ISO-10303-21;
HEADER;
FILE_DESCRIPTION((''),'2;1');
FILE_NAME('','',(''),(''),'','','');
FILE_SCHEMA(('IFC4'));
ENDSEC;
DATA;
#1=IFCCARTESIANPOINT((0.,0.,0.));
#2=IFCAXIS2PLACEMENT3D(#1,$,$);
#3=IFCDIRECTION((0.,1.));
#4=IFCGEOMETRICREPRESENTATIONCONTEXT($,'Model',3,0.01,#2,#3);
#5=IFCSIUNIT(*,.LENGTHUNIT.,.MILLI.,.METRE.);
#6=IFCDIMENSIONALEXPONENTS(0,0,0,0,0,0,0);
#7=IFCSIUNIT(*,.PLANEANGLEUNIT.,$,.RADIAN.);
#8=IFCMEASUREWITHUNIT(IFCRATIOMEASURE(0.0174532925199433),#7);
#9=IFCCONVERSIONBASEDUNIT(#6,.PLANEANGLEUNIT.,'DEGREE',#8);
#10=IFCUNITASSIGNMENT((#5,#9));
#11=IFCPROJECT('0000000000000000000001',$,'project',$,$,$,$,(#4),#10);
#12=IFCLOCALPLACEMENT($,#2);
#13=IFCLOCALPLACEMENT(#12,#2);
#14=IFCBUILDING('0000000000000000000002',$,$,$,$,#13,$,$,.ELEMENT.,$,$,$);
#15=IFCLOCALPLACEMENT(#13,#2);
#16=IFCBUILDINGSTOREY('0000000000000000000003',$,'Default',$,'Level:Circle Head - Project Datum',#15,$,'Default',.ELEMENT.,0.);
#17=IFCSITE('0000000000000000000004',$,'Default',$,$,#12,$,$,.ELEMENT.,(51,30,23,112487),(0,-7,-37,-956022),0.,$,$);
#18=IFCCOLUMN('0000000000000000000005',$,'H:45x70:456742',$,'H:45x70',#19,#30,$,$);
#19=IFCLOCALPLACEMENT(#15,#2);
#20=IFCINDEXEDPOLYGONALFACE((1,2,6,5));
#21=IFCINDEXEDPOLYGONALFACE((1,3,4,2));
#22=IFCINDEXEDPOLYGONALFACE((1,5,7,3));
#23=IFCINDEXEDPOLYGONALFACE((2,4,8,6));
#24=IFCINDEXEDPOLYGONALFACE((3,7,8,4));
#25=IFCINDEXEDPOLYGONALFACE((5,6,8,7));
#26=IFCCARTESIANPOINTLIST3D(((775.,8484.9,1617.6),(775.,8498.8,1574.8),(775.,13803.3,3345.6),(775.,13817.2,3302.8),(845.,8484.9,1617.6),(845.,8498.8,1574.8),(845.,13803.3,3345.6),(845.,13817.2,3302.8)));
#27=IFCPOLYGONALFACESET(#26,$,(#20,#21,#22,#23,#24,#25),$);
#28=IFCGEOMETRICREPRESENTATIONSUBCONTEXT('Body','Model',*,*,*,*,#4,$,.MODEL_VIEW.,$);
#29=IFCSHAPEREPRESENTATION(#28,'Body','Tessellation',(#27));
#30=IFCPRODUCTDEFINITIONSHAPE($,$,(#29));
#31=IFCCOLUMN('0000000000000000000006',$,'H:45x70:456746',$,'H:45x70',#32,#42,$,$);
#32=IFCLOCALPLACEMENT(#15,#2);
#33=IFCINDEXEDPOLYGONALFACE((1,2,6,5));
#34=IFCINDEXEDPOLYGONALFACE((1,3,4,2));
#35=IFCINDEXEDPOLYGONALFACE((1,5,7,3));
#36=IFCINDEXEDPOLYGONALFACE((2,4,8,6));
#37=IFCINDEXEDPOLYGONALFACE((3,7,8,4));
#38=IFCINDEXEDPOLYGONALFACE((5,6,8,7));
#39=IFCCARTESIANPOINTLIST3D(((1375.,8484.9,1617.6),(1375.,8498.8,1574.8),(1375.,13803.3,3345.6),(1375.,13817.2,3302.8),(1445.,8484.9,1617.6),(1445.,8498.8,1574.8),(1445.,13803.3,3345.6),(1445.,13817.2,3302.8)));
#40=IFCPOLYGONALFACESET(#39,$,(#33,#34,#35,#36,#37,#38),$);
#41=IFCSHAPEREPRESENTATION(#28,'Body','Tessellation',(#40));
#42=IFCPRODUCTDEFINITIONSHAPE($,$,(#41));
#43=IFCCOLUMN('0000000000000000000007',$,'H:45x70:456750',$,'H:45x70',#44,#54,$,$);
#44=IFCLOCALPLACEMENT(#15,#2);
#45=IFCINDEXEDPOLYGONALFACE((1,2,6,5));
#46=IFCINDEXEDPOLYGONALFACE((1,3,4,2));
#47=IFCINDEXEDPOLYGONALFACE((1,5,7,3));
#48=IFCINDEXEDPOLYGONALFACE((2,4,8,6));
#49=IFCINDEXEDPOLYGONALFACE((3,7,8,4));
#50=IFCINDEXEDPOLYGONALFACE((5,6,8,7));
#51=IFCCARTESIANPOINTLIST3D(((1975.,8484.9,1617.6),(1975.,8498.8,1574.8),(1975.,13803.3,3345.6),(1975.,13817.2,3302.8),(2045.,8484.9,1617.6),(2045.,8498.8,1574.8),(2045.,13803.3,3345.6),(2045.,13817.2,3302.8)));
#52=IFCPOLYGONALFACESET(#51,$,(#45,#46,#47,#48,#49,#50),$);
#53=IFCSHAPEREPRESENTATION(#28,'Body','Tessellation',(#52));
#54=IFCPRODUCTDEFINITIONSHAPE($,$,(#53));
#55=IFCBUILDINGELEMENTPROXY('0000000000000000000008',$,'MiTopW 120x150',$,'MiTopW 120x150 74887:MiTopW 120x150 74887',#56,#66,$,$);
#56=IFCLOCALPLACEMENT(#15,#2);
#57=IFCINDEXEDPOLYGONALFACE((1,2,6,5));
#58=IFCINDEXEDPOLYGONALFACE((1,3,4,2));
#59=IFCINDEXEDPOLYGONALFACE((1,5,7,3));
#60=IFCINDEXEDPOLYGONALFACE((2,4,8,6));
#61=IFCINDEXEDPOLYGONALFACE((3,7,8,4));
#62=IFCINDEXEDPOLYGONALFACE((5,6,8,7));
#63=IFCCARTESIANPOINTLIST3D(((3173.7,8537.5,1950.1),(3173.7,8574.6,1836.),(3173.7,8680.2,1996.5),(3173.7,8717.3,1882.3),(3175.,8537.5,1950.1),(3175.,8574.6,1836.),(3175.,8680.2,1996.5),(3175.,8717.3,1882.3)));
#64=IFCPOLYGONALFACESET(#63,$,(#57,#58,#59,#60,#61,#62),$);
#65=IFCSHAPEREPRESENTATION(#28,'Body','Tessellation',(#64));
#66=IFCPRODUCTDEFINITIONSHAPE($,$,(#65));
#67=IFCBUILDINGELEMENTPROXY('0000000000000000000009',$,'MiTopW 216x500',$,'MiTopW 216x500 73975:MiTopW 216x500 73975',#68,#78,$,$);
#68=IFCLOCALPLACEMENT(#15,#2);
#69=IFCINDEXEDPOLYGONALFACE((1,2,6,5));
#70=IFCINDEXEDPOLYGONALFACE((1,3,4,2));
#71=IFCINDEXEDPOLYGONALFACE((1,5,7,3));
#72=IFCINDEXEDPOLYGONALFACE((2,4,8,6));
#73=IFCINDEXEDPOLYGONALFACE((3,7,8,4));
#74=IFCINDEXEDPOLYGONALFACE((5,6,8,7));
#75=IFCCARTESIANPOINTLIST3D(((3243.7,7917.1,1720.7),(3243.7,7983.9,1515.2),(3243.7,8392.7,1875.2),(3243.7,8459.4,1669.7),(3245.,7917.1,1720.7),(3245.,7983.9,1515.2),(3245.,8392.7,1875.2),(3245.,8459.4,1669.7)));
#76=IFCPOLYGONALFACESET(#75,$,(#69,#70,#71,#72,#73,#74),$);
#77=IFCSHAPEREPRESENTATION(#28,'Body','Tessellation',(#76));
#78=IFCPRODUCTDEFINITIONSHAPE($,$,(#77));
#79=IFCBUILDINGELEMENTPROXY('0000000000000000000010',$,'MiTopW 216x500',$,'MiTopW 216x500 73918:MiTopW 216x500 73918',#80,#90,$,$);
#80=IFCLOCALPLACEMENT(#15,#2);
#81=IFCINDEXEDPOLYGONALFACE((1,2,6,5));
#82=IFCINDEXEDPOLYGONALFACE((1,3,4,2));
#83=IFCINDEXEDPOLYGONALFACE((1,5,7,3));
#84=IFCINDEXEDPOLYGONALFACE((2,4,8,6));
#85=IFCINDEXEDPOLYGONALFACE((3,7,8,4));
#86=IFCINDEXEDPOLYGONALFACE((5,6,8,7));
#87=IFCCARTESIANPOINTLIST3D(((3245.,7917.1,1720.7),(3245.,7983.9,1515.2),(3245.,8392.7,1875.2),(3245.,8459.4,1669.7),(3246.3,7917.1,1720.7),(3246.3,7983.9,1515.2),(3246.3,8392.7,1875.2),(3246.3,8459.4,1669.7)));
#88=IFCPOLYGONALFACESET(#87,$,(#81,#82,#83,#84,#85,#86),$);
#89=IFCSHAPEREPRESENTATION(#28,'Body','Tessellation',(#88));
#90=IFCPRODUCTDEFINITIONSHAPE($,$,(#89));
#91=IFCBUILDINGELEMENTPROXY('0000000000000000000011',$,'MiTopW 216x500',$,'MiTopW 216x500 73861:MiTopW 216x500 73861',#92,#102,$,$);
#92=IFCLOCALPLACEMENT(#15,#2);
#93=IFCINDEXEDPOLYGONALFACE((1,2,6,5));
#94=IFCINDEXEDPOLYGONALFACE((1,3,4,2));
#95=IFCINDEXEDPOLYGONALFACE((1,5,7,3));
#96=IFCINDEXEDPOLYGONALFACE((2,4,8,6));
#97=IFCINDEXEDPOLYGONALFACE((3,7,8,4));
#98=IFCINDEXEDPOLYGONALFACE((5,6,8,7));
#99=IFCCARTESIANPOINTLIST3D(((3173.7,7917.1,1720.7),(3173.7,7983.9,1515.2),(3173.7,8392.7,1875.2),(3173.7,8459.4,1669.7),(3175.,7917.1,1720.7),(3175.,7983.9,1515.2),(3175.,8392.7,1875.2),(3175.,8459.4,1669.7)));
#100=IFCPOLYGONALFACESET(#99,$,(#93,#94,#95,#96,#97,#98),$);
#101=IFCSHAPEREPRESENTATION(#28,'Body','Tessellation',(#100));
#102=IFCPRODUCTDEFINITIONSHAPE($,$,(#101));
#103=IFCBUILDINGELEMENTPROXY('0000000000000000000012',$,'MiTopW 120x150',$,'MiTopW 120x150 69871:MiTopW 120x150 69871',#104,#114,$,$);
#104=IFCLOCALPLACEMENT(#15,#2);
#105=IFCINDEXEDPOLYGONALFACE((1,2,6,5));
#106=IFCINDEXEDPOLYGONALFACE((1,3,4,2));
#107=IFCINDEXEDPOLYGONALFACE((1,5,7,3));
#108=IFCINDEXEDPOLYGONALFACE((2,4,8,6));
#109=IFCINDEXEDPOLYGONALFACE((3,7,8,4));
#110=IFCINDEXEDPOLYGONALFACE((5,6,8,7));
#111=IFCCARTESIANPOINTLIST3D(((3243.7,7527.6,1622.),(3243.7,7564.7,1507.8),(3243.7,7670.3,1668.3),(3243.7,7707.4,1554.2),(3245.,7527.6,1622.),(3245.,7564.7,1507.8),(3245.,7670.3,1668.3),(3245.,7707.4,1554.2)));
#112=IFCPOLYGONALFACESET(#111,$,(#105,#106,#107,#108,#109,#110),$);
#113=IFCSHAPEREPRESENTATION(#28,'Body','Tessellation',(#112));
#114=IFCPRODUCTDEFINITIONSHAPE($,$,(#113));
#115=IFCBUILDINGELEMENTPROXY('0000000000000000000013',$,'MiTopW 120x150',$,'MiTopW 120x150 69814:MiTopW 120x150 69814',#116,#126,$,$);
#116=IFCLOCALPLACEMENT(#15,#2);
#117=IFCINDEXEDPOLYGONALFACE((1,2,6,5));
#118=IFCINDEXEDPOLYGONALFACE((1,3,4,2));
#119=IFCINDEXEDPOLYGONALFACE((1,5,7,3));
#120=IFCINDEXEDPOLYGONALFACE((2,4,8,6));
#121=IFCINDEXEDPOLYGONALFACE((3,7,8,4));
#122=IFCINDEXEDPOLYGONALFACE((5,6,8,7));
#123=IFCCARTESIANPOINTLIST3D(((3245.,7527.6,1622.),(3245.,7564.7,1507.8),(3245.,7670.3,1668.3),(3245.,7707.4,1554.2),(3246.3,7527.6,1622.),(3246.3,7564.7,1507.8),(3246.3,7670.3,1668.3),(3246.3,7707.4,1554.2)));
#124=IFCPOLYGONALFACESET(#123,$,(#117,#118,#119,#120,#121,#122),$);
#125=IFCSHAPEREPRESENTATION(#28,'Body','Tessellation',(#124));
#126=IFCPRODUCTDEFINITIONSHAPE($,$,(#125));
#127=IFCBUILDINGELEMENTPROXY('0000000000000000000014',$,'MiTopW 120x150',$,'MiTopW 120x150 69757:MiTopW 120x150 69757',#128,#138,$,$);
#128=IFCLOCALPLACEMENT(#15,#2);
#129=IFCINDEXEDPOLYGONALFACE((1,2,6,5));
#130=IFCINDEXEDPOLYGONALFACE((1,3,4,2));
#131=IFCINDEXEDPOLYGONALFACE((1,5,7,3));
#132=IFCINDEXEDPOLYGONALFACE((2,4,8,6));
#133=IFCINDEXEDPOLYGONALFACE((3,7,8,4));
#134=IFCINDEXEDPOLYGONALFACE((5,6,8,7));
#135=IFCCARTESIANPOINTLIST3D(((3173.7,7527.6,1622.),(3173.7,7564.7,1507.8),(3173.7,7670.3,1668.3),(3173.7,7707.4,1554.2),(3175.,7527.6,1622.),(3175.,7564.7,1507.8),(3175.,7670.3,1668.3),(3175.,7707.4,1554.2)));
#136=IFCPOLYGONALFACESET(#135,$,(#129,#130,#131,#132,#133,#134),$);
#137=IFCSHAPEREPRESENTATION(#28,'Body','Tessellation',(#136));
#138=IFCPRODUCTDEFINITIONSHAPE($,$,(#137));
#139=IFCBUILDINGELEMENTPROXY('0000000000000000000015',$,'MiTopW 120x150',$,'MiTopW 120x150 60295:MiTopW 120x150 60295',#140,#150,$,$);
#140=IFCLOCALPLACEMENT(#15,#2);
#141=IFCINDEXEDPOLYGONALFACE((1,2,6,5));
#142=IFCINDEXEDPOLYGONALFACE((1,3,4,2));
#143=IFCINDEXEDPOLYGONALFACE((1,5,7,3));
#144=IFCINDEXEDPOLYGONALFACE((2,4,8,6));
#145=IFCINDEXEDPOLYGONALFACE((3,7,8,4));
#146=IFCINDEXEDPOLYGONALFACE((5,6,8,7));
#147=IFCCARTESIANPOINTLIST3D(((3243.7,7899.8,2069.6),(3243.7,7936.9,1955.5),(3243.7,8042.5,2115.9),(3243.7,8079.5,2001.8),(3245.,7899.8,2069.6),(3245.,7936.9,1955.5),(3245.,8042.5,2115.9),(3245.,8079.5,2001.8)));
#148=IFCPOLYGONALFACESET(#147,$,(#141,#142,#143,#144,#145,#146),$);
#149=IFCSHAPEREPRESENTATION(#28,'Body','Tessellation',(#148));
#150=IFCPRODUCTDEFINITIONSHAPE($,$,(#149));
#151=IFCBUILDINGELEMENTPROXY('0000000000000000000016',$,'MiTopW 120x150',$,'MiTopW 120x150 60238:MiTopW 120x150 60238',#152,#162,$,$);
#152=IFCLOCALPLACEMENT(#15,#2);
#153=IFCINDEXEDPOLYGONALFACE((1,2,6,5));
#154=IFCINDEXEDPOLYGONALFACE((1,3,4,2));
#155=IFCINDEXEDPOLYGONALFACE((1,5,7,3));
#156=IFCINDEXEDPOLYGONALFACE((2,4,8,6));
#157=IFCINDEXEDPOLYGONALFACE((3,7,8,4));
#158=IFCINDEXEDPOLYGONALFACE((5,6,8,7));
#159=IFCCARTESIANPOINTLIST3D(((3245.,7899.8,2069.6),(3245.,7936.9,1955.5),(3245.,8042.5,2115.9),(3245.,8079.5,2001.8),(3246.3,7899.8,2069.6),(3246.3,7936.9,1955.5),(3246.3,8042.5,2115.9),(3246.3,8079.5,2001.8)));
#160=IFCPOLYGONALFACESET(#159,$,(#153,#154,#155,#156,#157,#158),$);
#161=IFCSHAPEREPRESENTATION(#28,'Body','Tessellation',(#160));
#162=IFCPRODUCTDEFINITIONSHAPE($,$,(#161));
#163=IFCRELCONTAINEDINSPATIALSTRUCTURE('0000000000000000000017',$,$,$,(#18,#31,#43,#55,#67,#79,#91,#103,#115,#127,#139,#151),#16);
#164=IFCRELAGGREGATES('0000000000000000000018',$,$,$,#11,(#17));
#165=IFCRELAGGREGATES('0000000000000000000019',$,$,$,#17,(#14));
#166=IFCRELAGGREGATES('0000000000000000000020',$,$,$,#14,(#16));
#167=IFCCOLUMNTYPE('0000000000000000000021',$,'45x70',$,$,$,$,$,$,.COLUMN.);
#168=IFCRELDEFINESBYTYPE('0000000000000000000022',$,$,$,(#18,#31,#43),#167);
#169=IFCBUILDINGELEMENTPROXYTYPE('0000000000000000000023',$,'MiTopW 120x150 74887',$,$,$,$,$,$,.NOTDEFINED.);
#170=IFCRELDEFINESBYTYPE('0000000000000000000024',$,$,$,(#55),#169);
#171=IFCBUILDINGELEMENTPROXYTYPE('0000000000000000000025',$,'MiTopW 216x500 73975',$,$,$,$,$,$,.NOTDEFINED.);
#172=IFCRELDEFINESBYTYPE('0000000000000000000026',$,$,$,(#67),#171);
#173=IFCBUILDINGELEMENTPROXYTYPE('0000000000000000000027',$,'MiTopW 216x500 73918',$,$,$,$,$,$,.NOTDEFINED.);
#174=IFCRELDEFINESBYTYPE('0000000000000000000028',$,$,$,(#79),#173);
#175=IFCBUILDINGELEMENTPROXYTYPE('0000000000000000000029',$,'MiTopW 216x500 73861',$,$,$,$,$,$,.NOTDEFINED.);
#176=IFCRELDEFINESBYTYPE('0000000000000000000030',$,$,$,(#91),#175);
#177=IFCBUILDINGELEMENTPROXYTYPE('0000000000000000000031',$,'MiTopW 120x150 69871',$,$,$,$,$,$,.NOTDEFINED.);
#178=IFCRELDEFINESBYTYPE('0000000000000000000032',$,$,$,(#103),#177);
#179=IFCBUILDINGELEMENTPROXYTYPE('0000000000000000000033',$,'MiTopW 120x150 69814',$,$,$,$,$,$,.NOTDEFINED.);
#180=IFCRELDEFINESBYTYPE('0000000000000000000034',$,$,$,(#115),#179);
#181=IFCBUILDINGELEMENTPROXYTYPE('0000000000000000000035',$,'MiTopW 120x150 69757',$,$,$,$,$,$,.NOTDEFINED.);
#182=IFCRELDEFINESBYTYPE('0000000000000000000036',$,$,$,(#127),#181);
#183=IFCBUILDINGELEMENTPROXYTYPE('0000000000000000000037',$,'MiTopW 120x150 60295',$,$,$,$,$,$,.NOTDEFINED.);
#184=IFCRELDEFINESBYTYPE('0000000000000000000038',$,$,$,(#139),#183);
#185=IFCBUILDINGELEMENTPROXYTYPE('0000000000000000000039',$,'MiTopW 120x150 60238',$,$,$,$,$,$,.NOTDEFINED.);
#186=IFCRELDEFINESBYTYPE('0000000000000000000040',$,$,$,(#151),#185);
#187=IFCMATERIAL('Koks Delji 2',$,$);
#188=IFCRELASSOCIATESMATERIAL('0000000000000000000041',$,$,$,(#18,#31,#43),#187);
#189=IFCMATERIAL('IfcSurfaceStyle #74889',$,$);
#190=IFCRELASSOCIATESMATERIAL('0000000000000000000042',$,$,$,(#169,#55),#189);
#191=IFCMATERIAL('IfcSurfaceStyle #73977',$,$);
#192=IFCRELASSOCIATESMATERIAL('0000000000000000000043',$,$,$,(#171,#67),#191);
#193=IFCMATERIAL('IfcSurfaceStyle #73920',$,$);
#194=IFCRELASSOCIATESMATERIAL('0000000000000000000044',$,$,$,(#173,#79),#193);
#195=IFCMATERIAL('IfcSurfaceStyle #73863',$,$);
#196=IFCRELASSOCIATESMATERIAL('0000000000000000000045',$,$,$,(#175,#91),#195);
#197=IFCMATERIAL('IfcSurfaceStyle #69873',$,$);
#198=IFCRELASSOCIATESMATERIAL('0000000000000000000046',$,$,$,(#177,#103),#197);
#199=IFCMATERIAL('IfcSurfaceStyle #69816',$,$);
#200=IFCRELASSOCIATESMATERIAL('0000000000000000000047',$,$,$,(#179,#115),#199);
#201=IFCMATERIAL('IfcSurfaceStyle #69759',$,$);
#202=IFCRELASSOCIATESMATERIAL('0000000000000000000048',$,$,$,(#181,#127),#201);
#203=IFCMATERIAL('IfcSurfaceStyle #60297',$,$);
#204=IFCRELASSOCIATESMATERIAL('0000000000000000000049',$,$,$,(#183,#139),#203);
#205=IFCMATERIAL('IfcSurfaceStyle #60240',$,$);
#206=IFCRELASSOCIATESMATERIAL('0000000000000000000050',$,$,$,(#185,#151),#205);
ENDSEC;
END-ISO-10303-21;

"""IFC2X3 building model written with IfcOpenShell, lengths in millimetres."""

from ifc_helpers import new_model, entity, si_unit, converted_unit, direction, frame, frame_2d, origin, place, context, subcontext, project, spatial, polyline, rectangle, outline, extrude, source, transform, mapped, material, type_object, type_shapes, element, save


model = new_model("IFC2X3")

# Units and contexts
model_context = context("Model", 3, precision=0.01, world=origin(), true_north=direction((0.0, 1.0)))
body_context = subcontext(model_context, "Body", "Model", "MODEL_VIEW")
ifc_project = project(units=[si_unit("LENGTHUNIT", "METRE", prefix="MILLI"), converted_unit("PLANEANGLEUNIT", "DEGREE", entity("IfcRatioMeasure", 0.0174532925199433), si_unit("PLANEANGLEUNIT", "RADIAN"), dimensions=[0, 0, 0, 0, 0, 0, 0])], contexts=[model_context])

# Site, building, storey
site_placement = place(None, origin())
site = spatial("IfcSite", under=ifc_project, at=site_placement, Name="Default", CompositionType="ELEMENT", RefLatitude=(51, 30, 23, 112487), RefLongitude=(0, -7, -37, -956022), RefElevation=0.0)
building_placement = place(site_placement, origin())
building = spatial("IfcBuilding", under=site, at=building_placement, CompositionType="ELEMENT")
storey_placement = place(building_placement, origin())
storey = spatial("IfcBuildingStorey", under=building, at=storey_placement, Name="Default", ObjectType="Level:Circle Head - Project Datum", LongName="Default", CompositionType="ELEMENT", Elevation=0.0)

# Columns
ifc_material_1 = material(Name="Koks Delji 2")
column_type_1 = type_object("IfcColumnType", Name="45x70", PredefinedType="COLUMN")
shared_shape_1 = source(origin(), body_context, "Body", "SweptSolid", [
    extrude(rectangle(XDim=5592.1, YDim=70.0, at=frame_2d((0.0, 0.0), x_axis=(1.0, 0.0))), frame((2659.2, 237.8, 864.0), z_axis=(-0.309017, 0.0, 0.951057), x_axis=(-0.951057, 0.0, -0.309017)), (0.0, 0.0, 1.0), 45.0),
])
type_shapes(column_type_1, [shared_shape_1])
for number, where, z_axis, x_axis, name in (
    (1, (1047.8, 8498.8, 1574.8), (0.0, 0.0, 1.0), (0.0, 1.0, 0.0), "H:45x70:456742"),
    (2, (1647.8, 8498.8, 1574.8), (0.0, 0.0, 1.0), (0.0, 1.0, 0.0), "H:45x70:456746"),
    (3, (2247.8, 8498.8, 1574.8), (0.0, 0.0, 1.0), (0.0, 1.0, 0.0), "H:45x70:456750"),
):
    element("IfcColumn", number, at=place(storey_placement, frame(where, z_axis=z_axis, x_axis=x_axis)), inside=storey, type_object=column_type_1, material=ifc_material_1, Name=name, ObjectType="H:45x70", context=body_context, shape_type="MappedRepresentation", body=[
        mapped(shared_shape_1, transform((0.0, 0.0, 0.0), scale=1.0)),
    ])

# Building element proxies
ifc_material_2 = material(Name="IfcSurfaceStyle #74889")
building_element_proxy_type_1 = type_object("IfcBuildingElementProxyType", Name="MiTopW 120x150 74887", PredefinedType="NOTDEFINED", material=ifc_material_2)
shared_shape_2 = source(origin(), body_context, "Body", "SweptSolid", [
    extrude(outline(polyline([(-75.0, -60.0), (75.0, -60.0), (75.0, 60.0), (-75.0, 60.0), (-75.0, -60.0)])), frame((75.0, 60.0, 0.0), z_axis=(0.0, 0.0, 1.0), x_axis=(-1.0, 0.0, 0.0)), (0.0, 0.0, 1.0), 1.3),
])
type_shapes(building_element_proxy_type_1, [shared_shape_2])
proxy_1_placement = place(building_placement, frame((3175.0, 8537.5, 1950.1), z_axis=(-1.0, 0.0, 0.0), x_axis=(0.0, 0.951057, 0.309017)))
element("IfcBuildingElementProxy", 4, at=proxy_1_placement, inside=storey, type_object=building_element_proxy_type_1, material=ifc_material_2, Name="MiTopW 120x150", ObjectType="MiTopW 120x150 74887:MiTopW 120x150 74887", context=body_context, shape_type="MappedRepresentation", body=[
    mapped(shared_shape_2, transform((0.0, 0.0, 0.0), scale=1.0)),
])
ifc_material_3 = material(Name="IfcSurfaceStyle #73977")
building_element_proxy_type_2 = type_object("IfcBuildingElementProxyType", Name="MiTopW 216x500 73975", PredefinedType="NOTDEFINED", material=ifc_material_3)
shared_shape_3 = source(origin(), body_context, "Body", "SweptSolid", [
    extrude(outline(polyline([(-250.0, -108.0), (250.0, -108.0), (250.0, 108.0), (-250.0, 108.0), (-250.0, -108.0)])), frame((250.0, 108.0, 0.0), z_axis=(0.0, 0.0, 1.0), x_axis=(-1.0, 0.0, 0.0)), (0.0, 0.0, 1.0), 1.3),
])
type_shapes(building_element_proxy_type_2, [shared_shape_3])
proxy_2_placement = place(building_placement, frame((3245.0, 7917.1, 1720.7), z_axis=(-1.0, 0.0, 0.0), x_axis=(0.0, 0.951057, 0.309017)))
element("IfcBuildingElementProxy", 5, at=proxy_2_placement, inside=storey, type_object=building_element_proxy_type_2, material=ifc_material_3, Name="MiTopW 216x500", ObjectType="MiTopW 216x500 73975:MiTopW 216x500 73975", context=body_context, shape_type="MappedRepresentation", body=[
    mapped(shared_shape_3, transform((0.0, 0.0, 0.0), scale=1.0)),
])
ifc_material_4 = material(Name="IfcSurfaceStyle #73920")
building_element_proxy_type_3 = type_object("IfcBuildingElementProxyType", Name="MiTopW 216x500 73918", PredefinedType="NOTDEFINED", material=ifc_material_4)
shared_shape_4 = source(origin(), body_context, "Body", "SweptSolid", [
    extrude(outline(polyline([(-250.0, -108.0), (250.0, -108.0), (250.0, 108.0), (-250.0, 108.0), (-250.0, -108.0)])), frame((250.0, 108.0, 0.0), z_axis=(0.0, 0.0, 1.0), x_axis=(-1.0, 0.0, 0.0)), (0.0, 0.0, 1.0), 1.3),
])
type_shapes(building_element_proxy_type_3, [shared_shape_4])
proxy_3_placement = place(building_placement, frame((3246.3, 7917.1, 1720.7), z_axis=(-1.0, 0.0, 0.0), x_axis=(0.0, 0.951057, 0.309017)))
element("IfcBuildingElementProxy", 6, at=proxy_3_placement, inside=storey, type_object=building_element_proxy_type_3, material=ifc_material_4, Name="MiTopW 216x500", ObjectType="MiTopW 216x500 73918:MiTopW 216x500 73918", context=body_context, shape_type="MappedRepresentation", body=[
    mapped(shared_shape_4, transform((0.0, 0.0, 0.0), scale=1.0)),
])
ifc_material_5 = material(Name="IfcSurfaceStyle #73863")
building_element_proxy_type_4 = type_object("IfcBuildingElementProxyType", Name="MiTopW 216x500 73861", PredefinedType="NOTDEFINED", material=ifc_material_5)
shared_shape_5 = source(origin(), body_context, "Body", "SweptSolid", [
    extrude(outline(polyline([(-250.0, -108.0), (250.0, -108.0), (250.0, 108.0), (-250.0, 108.0), (-250.0, -108.0)])), frame((250.0, 108.0, 0.0), z_axis=(0.0, 0.0, 1.0), x_axis=(-1.0, 0.0, 0.0)), (0.0, 0.0, 1.0), 1.3),
])
type_shapes(building_element_proxy_type_4, [shared_shape_5])
proxy_4_placement = place(building_placement, frame((3175.0, 7917.1, 1720.7), z_axis=(-1.0, 0.0, 0.0), x_axis=(0.0, 0.951057, 0.309017)))
element("IfcBuildingElementProxy", 7, at=proxy_4_placement, inside=storey, type_object=building_element_proxy_type_4, material=ifc_material_5, Name="MiTopW 216x500", ObjectType="MiTopW 216x500 73861:MiTopW 216x500 73861", context=body_context, shape_type="MappedRepresentation", body=[
    mapped(shared_shape_5, transform((0.0, 0.0, 0.0), scale=1.0)),
])
ifc_material_6 = material(Name="IfcSurfaceStyle #69873")
building_element_proxy_type_5 = type_object("IfcBuildingElementProxyType", Name="MiTopW 120x150 69871", PredefinedType="NOTDEFINED", material=ifc_material_6)
shared_shape_6 = source(origin(), body_context, "Body", "SweptSolid", [
    extrude(outline(polyline([(-75.0, -60.0), (75.0, -60.0), (75.0, 60.0), (-75.0, 60.0), (-75.0, -60.0)])), frame((75.0, 60.0, 0.0), z_axis=(0.0, 0.0, 1.0), x_axis=(-1.0, 0.0, 0.0)), (0.0, 0.0, 1.0), 1.3),
])
type_shapes(building_element_proxy_type_5, [shared_shape_6])
proxy_5_placement = place(building_placement, frame((3245.0, 7527.6, 1622.0), z_axis=(-1.0, 0.0, 0.0), x_axis=(0.0, 0.951057, 0.309017)))
element("IfcBuildingElementProxy", 8, at=proxy_5_placement, inside=storey, type_object=building_element_proxy_type_5, material=ifc_material_6, Name="MiTopW 120x150", ObjectType="MiTopW 120x150 69871:MiTopW 120x150 69871", context=body_context, shape_type="MappedRepresentation", body=[
    mapped(shared_shape_6, transform((0.0, 0.0, 0.0), scale=1.0)),
])
ifc_material_7 = material(Name="IfcSurfaceStyle #69816")
building_element_proxy_type_6 = type_object("IfcBuildingElementProxyType", Name="MiTopW 120x150 69814", PredefinedType="NOTDEFINED", material=ifc_material_7)
shared_shape_7 = source(origin(), body_context, "Body", "SweptSolid", [
    extrude(outline(polyline([(-75.0, -60.0), (75.0, -60.0), (75.0, 60.0), (-75.0, 60.0), (-75.0, -60.0)])), frame((75.0, 60.0, 0.0), z_axis=(0.0, 0.0, 1.0), x_axis=(-1.0, 0.0, 0.0)), (0.0, 0.0, 1.0), 1.3),
])
type_shapes(building_element_proxy_type_6, [shared_shape_7])
proxy_6_placement = place(building_placement, frame((3246.3, 7527.6, 1622.0), z_axis=(-1.0, 0.0, 0.0), x_axis=(0.0, 0.951057, 0.309017)))
element("IfcBuildingElementProxy", 9, at=proxy_6_placement, inside=storey, type_object=building_element_proxy_type_6, material=ifc_material_7, Name="MiTopW 120x150", ObjectType="MiTopW 120x150 69814:MiTopW 120x150 69814", context=body_context, shape_type="MappedRepresentation", body=[
    mapped(shared_shape_7, transform((0.0, 0.0, 0.0), scale=1.0)),
])
ifc_material_8 = material(Name="IfcSurfaceStyle #69759")
building_element_proxy_type_7 = type_object("IfcBuildingElementProxyType", Name="MiTopW 120x150 69757", PredefinedType="NOTDEFINED", material=ifc_material_8)
shared_shape_8 = source(origin(), body_context, "Body", "SweptSolid", [
    extrude(outline(polyline([(-75.0, -60.0), (75.0, -60.0), (75.0, 60.0), (-75.0, 60.0), (-75.0, -60.0)])), frame((75.0, 60.0, 0.0), z_axis=(0.0, 0.0, 1.0), x_axis=(-1.0, 0.0, 0.0)), (0.0, 0.0, 1.0), 1.3),
])
type_shapes(building_element_proxy_type_7, [shared_shape_8])
proxy_7_placement = place(building_placement, frame((3175.0, 7527.6, 1622.0), z_axis=(-1.0, 0.0, 0.0), x_axis=(0.0, 0.951057, 0.309017)))
element("IfcBuildingElementProxy", 10, at=proxy_7_placement, inside=storey, type_object=building_element_proxy_type_7, material=ifc_material_8, Name="MiTopW 120x150", ObjectType="MiTopW 120x150 69757:MiTopW 120x150 69757", context=body_context, shape_type="MappedRepresentation", body=[
    mapped(shared_shape_8, transform((0.0, 0.0, 0.0), scale=1.0)),
])
ifc_material_9 = material(Name="IfcSurfaceStyle #60297")
building_element_proxy_type_8 = type_object("IfcBuildingElementProxyType", Name="MiTopW 120x150 60295", PredefinedType="NOTDEFINED", material=ifc_material_9)
shared_shape_9 = source(origin(), body_context, "Body", "SweptSolid", [
    extrude(outline(polyline([(-75.0, -60.0), (75.0, -60.0), (75.0, 60.0), (-75.0, 60.0), (-75.0, -60.0)])), frame((75.0, 60.0, 0.0), z_axis=(0.0, 0.0, 1.0), x_axis=(-1.0, 0.0, 0.0)), (0.0, 0.0, 1.0), 1.3),
])
type_shapes(building_element_proxy_type_8, [shared_shape_9])
proxy_8_placement = place(building_placement, frame((3245.0, 7899.8, 2069.6), z_axis=(-1.0, 0.0, 0.0), x_axis=(0.0, 0.951057, 0.309017)))
element("IfcBuildingElementProxy", 11, at=proxy_8_placement, inside=storey, type_object=building_element_proxy_type_8, material=ifc_material_9, Name="MiTopW 120x150", ObjectType="MiTopW 120x150 60295:MiTopW 120x150 60295", context=body_context, shape_type="MappedRepresentation", body=[
    mapped(shared_shape_9, transform((0.0, 0.0, 0.0), scale=1.0)),
])
ifc_material_10 = material(Name="IfcSurfaceStyle #60240")
building_element_proxy_type_9 = type_object("IfcBuildingElementProxyType", Name="MiTopW 120x150 60238", PredefinedType="NOTDEFINED", material=ifc_material_10)
shared_shape_10 = source(origin(), body_context, "Body", "SweptSolid", [
    extrude(outline(polyline([(-75.0, -60.0), (75.0, -60.0), (75.0, 60.0), (-75.0, 60.0), (-75.0, -60.0)])), frame((75.0, 60.0, 0.0), z_axis=(0.0, 0.0, 1.0), x_axis=(-1.0, 0.0, 0.0)), (0.0, 0.0, 1.0), 1.3),
])
type_shapes(building_element_proxy_type_9, [shared_shape_10])
proxy_9_placement = place(building_placement, frame((3246.3, 7899.8, 2069.6), z_axis=(-1.0, 0.0, 0.0), x_axis=(0.0, 0.951057, 0.309017)))
element("IfcBuildingElementProxy", 12, at=proxy_9_placement, inside=storey, type_object=building_element_proxy_type_9, material=ifc_material_10, Name="MiTopW 120x150", ObjectType="MiTopW 120x150 60238:MiTopW 120x150 60238", context=body_context, shape_type="MappedRepresentation", body=[
    mapped(shared_shape_10, transform((0.0, 0.0, 0.0), scale=1.0)),
])

save(model, "model.ifc")
